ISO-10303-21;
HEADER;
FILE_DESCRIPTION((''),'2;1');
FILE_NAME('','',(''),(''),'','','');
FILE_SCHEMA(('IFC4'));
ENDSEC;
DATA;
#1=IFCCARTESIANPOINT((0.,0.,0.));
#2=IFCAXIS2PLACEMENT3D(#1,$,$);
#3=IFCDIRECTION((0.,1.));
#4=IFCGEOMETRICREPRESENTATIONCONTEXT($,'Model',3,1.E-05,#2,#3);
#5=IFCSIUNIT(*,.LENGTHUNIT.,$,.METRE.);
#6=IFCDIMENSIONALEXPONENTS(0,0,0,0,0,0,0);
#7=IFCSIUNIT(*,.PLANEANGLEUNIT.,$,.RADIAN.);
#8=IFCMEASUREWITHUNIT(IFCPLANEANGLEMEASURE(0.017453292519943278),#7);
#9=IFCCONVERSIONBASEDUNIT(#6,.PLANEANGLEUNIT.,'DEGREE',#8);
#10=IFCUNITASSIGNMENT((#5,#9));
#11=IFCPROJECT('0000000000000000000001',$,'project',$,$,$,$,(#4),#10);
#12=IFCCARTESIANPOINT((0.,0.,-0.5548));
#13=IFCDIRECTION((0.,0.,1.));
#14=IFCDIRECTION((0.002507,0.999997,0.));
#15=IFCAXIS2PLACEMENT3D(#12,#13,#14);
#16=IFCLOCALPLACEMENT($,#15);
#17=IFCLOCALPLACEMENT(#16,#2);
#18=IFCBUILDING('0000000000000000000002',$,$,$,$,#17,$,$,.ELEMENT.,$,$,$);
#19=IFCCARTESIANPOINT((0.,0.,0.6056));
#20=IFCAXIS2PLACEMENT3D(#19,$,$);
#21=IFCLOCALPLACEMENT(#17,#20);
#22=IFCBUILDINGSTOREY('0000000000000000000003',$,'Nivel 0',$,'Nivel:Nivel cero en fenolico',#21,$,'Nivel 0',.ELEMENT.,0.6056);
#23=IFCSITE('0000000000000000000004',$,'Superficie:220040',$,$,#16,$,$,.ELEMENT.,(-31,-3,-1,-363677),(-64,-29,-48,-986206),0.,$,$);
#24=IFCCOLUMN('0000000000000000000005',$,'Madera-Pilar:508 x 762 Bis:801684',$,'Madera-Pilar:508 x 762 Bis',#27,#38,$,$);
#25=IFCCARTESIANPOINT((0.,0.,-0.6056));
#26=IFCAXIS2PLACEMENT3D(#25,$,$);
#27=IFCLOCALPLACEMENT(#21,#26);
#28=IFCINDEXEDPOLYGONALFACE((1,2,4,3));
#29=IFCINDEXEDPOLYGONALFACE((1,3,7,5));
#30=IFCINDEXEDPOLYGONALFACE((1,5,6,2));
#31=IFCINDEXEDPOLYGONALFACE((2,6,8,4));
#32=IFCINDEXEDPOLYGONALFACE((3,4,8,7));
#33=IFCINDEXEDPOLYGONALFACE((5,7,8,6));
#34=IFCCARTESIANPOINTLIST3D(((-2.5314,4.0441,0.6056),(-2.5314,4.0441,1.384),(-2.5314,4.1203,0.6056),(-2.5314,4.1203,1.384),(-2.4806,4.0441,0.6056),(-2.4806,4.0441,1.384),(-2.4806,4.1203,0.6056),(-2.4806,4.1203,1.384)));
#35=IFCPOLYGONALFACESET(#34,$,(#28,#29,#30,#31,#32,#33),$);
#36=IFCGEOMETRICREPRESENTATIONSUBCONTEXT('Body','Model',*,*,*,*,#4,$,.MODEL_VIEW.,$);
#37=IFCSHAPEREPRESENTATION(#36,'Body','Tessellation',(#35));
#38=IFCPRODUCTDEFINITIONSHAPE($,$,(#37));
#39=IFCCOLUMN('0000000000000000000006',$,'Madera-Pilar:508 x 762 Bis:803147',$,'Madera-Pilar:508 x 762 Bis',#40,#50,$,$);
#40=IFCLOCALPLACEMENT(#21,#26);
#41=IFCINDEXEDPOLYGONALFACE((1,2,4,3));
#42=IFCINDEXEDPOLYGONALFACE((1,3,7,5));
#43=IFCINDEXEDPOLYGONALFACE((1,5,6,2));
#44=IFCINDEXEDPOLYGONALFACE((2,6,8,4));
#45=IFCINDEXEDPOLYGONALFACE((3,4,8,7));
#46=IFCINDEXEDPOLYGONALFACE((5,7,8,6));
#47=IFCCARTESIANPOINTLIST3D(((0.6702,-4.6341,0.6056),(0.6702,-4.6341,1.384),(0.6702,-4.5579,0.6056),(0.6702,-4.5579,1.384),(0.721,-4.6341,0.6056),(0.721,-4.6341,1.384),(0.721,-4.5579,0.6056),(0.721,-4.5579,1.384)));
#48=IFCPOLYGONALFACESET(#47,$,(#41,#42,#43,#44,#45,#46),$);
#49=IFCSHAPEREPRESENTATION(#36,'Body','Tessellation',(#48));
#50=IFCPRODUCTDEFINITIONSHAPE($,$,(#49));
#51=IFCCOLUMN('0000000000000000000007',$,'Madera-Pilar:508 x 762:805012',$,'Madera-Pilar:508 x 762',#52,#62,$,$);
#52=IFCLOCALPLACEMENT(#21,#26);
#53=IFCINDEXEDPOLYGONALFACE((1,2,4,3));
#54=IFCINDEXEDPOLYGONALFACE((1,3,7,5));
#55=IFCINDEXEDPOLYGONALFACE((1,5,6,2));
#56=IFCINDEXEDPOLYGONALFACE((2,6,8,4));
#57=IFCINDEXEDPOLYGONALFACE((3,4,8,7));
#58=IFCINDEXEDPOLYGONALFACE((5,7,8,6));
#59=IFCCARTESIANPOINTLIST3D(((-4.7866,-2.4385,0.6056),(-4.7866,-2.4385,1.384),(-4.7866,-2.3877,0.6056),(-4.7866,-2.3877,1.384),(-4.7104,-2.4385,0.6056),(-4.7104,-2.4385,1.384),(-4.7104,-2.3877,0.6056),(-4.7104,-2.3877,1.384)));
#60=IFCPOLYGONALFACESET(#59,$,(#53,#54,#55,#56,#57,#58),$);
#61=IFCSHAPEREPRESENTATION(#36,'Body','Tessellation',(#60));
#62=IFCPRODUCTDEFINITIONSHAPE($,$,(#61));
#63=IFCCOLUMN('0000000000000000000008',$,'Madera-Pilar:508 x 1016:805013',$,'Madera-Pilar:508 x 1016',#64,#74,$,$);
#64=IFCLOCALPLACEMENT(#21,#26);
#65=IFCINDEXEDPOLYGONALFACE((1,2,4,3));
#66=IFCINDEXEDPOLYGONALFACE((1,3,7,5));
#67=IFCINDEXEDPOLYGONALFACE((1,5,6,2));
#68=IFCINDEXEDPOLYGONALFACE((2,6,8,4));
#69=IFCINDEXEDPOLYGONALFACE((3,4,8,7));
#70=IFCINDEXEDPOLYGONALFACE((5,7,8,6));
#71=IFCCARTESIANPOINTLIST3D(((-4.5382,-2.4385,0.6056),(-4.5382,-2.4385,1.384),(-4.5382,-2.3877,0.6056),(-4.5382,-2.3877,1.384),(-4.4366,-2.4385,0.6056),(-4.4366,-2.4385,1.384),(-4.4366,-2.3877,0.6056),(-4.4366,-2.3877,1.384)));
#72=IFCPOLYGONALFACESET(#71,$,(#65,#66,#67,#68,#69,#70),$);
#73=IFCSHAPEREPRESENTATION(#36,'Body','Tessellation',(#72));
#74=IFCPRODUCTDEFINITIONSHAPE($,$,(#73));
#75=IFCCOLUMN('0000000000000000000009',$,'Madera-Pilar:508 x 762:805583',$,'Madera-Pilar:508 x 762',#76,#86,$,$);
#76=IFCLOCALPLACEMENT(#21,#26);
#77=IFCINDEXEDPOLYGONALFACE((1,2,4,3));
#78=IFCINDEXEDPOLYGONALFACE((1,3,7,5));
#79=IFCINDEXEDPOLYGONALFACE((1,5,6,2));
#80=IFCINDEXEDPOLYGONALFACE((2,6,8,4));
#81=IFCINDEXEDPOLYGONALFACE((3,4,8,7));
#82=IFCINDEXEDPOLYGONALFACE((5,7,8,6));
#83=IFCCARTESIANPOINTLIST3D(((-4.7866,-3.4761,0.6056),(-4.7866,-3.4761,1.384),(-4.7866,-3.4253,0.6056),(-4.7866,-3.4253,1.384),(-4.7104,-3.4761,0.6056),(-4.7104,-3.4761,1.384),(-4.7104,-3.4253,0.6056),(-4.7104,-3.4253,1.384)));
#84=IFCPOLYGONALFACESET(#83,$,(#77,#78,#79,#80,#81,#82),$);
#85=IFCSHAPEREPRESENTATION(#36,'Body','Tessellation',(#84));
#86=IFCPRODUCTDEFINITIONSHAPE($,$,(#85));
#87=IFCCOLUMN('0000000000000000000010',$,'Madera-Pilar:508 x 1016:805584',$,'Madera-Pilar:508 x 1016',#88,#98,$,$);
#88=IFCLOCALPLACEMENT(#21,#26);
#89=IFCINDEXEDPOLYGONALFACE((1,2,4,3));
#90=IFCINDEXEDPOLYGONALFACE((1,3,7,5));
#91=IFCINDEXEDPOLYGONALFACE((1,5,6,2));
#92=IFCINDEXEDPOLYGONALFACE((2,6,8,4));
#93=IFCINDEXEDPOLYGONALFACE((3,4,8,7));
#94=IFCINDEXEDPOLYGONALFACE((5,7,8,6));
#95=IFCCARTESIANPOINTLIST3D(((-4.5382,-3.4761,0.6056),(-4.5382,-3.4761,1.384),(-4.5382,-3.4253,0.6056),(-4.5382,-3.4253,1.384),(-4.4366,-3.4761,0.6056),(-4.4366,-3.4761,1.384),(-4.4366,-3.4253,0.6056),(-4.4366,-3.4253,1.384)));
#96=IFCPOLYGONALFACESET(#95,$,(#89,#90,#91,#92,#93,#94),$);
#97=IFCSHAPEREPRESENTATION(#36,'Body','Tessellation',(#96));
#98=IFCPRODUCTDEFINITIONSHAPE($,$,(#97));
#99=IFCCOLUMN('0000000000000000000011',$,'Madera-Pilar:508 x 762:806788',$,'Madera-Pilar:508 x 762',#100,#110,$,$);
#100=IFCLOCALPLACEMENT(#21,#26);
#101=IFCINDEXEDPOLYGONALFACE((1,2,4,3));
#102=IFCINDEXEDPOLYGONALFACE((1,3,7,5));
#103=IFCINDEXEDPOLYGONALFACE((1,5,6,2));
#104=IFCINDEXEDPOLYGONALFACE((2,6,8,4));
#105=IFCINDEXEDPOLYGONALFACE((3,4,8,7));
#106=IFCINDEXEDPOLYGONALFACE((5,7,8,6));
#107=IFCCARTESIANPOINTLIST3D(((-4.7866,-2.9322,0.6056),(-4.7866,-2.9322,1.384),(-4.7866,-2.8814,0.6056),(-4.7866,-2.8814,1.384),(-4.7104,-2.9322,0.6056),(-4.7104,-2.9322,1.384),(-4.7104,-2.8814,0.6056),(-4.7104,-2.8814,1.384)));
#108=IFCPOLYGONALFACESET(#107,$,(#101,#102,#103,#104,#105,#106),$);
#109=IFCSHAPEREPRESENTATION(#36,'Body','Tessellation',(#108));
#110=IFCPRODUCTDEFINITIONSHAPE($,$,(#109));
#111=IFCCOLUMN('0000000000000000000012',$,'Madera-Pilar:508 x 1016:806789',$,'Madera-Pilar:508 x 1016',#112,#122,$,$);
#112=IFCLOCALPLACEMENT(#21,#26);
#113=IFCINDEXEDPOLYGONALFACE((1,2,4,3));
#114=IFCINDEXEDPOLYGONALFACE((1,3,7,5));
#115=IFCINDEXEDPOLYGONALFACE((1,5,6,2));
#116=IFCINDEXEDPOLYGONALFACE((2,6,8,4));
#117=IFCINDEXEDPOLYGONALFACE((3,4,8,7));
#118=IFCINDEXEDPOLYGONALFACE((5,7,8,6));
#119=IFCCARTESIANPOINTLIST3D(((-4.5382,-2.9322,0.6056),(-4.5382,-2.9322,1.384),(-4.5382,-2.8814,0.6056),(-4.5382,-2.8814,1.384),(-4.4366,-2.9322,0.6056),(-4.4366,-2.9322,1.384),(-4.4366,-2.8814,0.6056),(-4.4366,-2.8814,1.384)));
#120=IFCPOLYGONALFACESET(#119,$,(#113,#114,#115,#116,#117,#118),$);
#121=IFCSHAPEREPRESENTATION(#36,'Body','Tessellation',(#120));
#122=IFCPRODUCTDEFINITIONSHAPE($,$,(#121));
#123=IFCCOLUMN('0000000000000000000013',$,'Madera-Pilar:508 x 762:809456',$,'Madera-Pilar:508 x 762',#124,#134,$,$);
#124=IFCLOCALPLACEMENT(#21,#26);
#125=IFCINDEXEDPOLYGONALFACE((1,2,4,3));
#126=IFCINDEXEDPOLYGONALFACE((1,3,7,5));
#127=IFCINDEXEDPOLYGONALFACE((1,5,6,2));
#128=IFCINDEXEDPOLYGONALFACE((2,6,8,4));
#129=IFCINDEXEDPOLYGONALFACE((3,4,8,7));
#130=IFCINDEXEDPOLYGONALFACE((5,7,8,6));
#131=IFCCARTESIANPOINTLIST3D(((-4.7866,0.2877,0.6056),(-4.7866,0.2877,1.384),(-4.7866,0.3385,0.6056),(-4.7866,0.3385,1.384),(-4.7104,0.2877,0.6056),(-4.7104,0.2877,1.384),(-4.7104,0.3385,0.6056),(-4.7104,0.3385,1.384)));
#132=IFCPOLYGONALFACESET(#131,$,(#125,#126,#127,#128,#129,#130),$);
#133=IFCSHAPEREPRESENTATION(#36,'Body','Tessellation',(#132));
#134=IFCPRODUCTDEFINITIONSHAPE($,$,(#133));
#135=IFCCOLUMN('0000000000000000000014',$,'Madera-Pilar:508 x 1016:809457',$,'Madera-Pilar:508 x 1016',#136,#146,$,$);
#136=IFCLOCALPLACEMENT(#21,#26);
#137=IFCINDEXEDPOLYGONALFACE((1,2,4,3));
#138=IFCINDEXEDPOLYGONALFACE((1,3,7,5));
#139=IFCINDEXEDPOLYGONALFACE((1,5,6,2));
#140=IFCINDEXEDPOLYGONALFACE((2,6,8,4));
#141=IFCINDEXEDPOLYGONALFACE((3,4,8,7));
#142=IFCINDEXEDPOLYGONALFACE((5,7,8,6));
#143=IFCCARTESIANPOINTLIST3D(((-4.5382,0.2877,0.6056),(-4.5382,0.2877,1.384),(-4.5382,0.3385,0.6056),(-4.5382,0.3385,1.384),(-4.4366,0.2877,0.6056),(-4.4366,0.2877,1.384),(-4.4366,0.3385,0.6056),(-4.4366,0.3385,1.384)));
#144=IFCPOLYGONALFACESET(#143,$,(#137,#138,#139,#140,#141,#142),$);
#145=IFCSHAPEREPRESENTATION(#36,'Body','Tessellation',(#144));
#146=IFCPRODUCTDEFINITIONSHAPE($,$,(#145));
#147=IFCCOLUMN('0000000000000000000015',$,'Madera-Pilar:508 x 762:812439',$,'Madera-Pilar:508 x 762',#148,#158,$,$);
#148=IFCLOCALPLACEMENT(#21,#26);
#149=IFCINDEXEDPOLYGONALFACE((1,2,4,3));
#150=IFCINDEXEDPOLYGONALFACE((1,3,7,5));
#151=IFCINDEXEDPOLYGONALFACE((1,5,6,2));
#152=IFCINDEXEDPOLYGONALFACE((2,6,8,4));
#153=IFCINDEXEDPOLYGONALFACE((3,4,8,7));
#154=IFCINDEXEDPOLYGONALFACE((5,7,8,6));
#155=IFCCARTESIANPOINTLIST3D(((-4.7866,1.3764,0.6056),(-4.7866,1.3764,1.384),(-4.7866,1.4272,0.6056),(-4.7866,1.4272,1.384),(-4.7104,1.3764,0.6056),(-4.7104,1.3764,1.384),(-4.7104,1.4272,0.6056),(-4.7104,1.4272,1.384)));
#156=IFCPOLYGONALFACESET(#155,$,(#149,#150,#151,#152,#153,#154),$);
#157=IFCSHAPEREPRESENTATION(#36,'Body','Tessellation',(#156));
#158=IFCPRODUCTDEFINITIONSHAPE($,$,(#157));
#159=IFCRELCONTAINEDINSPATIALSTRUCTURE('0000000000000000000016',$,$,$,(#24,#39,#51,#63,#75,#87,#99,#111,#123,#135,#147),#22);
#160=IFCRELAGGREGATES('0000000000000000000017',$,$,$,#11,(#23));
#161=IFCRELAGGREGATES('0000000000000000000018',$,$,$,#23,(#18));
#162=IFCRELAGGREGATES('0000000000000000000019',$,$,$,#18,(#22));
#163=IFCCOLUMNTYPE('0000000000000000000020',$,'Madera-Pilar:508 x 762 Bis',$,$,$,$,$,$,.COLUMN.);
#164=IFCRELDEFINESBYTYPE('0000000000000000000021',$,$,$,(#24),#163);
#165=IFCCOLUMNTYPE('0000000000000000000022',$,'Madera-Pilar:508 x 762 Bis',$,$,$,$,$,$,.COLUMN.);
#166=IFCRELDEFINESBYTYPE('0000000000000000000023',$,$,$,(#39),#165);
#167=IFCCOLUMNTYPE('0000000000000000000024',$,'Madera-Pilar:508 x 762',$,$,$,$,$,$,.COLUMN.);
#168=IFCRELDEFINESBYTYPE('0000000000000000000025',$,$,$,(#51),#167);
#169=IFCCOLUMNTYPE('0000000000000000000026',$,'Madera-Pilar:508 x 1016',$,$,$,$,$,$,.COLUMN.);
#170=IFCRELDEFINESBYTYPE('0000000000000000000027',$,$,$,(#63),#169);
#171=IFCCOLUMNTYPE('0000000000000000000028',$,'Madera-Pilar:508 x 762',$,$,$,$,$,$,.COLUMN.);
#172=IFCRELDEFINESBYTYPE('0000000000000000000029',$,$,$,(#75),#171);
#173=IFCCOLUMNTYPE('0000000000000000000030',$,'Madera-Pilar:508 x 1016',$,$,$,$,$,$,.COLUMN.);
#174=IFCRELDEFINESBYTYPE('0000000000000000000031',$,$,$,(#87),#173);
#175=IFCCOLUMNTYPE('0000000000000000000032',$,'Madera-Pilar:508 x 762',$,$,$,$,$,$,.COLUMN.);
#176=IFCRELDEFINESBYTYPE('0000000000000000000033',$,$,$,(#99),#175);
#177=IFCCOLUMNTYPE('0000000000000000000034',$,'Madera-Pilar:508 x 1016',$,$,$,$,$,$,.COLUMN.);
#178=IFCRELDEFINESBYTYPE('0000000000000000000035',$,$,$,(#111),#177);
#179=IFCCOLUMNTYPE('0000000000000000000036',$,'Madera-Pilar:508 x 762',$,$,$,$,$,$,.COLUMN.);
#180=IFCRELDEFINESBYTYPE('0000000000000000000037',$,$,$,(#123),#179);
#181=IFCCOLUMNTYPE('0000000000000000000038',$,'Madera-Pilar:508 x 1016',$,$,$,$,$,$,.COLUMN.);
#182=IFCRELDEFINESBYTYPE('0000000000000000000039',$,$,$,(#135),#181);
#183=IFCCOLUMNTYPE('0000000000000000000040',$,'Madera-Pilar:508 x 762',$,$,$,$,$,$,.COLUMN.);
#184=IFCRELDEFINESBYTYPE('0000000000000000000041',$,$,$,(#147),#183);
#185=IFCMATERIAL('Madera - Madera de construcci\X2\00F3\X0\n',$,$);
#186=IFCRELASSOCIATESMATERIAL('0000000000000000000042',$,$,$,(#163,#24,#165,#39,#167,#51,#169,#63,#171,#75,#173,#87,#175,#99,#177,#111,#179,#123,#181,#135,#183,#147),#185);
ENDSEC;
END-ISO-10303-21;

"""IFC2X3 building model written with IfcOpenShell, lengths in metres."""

from ifc_helpers import new_model, entity, si_unit, converted_unit, direction, frame, frame_2d, origin, origin_2d_with_axis, place, context, subcontext, project, spatial, rectangle, extrude, source, transform, mapped, material, type_object, type_shapes, element, save


model = new_model("IFC2X3")

# Units and contexts
model_context = context("Model", 3, precision=1e-05, world=origin(), true_north=direction((0.0, 1.0)))
body_context = subcontext(model_context, "Body", "Model", "MODEL_VIEW")
ifc_project = project(units=[si_unit("LENGTHUNIT", "METRE"), converted_unit("PLANEANGLEUNIT", "DEGREE", entity("IfcPlaneAngleMeasure", 0.017453292519943278), si_unit("PLANEANGLEUNIT", "RADIAN"), dimensions=[0, 0, 0, 0, 0, 0, 0])], contexts=[model_context])

# Site, building, storey
site_placement = place(None, frame((0.0, 0.0, -0.5548), z_axis=(0.0, 0.0, 1.0), x_axis=(0.002507, 0.999997, 0.0)))
site = spatial("IfcSite", under=ifc_project, at=site_placement, Name="Superficie:220040", CompositionType="ELEMENT", RefLatitude=(-31, -3, -1, -363677), RefLongitude=(-64, -29, -48, -986206), RefElevation=0.0)
building_placement = place(site_placement, origin())
building = spatial("IfcBuilding", under=site, at=building_placement, CompositionType="ELEMENT")
storey_placement = place(building_placement, frame((0.0, 0.0, 0.6056)))
storey = spatial("IfcBuildingStorey", under=building, at=storey_placement, Name="Nivel 0", ObjectType="Nivel:Nivel cero en fenolico", LongName="Nivel 0", CompositionType="ELEMENT", Elevation=0.6056)

# Columns
ifc_material = material(Name="Madera - Madera de construcción")
column_type_1 = type_object("IfcColumnType", Name="Madera-Pilar:508 x 762 Bis", PredefinedType="COLUMN", material=ifc_material)
shared_shape_1 = source(origin(), body_context, "Body", "SweptSolid", [
    extrude(rectangle(XDim=0.0508, YDim=0.0762, at=frame_2d((0.0, 0.0), x_axis=(1.0, 0.0))), frame((-2.506, 4.0822, 0.6056), z_axis=(0.0, 0.0, 1.0), x_axis=(-1.0, 0.0, 0.0)), (0.0, 0.0, 1.0), 0.7784),
])
type_shapes(column_type_1, [shared_shape_1])
column_1_placement = place(storey_placement, frame((0.0, 0.0, -0.6056)))
element("IfcColumn", 1, at=column_1_placement, inside=storey, type_object=column_type_1, material=ifc_material, Name="Madera-Pilar:508 x 762 Bis:801684", ObjectType="Madera-Pilar:508 x 762 Bis", context=body_context, shape_type="MappedRepresentation", body=[
    mapped(shared_shape_1, transform((0.0, 0.0, 0.0), scale=1.0)),
])
column_type_2 = type_object("IfcColumnType", Name="Madera-Pilar:508 x 762 Bis", PredefinedType="COLUMN", material=ifc_material)
shared_shape_2 = source(origin(), body_context, "Body", "SweptSolid", [
    extrude(rectangle(XDim=0.0508, YDim=0.0762, at=frame_2d((0.0, 0.0), x_axis=(1.0, 0.0))), frame((0.6956, -4.596, 0.6056)), (0.0, 0.0, 1.0), 0.7784),
])
type_shapes(column_type_2, [shared_shape_2])
column_2_placement = place(storey_placement, frame((0.0, 0.0, -0.6056)))
element("IfcColumn", 2, at=column_2_placement, inside=storey, type_object=column_type_2, material=ifc_material, Name="Madera-Pilar:508 x 762 Bis:803147", ObjectType="Madera-Pilar:508 x 762 Bis", context=body_context, shape_type="MappedRepresentation", body=[
    mapped(shared_shape_2, transform((0.0, 0.0, 0.0), scale=1.0)),
])
column_type_3 = type_object("IfcColumnType", Name="Madera-Pilar:508 x 762", PredefinedType="COLUMN", material=ifc_material)
shared_shape_3 = source(origin(), body_context, "Body", "SweptSolid", [
    extrude(rectangle(XDim=0.0762, YDim=0.0508, at=origin_2d_with_axis()), frame((-4.7485, -2.4131, 0.6056), z_axis=(0.0, 0.0, 1.0), x_axis=(-1.0, 0.0, 0.0)), (0.0, 0.0, 1.0), 0.7784),
])
type_shapes(column_type_3, [shared_shape_3])
column_3_placement = place(storey_placement, frame((0.0, 0.0, -0.6056)))
element("IfcColumn", 3, at=column_3_placement, inside=storey, type_object=column_type_3, material=ifc_material, Name="Madera-Pilar:508 x 762:805012", ObjectType="Madera-Pilar:508 x 762", context=body_context, shape_type="MappedRepresentation", body=[
    mapped(shared_shape_3, transform((0.0, 0.0, 0.0), scale=1.0)),
])
column_type_4 = type_object("IfcColumnType", Name="Madera-Pilar:508 x 1016", PredefinedType="COLUMN", material=ifc_material)
shared_shape_4 = source(origin(), body_context, "Body", "SweptSolid", [
    extrude(rectangle(XDim=0.1016, YDim=0.0508, at=frame_2d((0.0, 0.0), x_axis=(1.0, 0.0))), frame((-4.4874, -2.4131, 0.6056), z_axis=(0.0, 0.0, 1.0), x_axis=(-1.0, 0.0, 0.0)), (0.0, 0.0, 1.0), 0.7784),
])
type_shapes(column_type_4, [shared_shape_4])
column_4_placement = place(storey_placement, frame((0.0, 0.0, -0.6056)))
element("IfcColumn", 4, at=column_4_placement, inside=storey, type_object=column_type_4, material=ifc_material, Name="Madera-Pilar:508 x 1016:805013", ObjectType="Madera-Pilar:508 x 1016", context=body_context, shape_type="MappedRepresentation", body=[
    mapped(shared_shape_4, transform((0.0, 0.0, 0.0), scale=1.0)),
])
column_type_5 = type_object("IfcColumnType", Name="Madera-Pilar:508 x 762", PredefinedType="COLUMN", material=ifc_material)
shared_shape_5 = source(origin(), body_context, "Body", "SweptSolid", [
    extrude(rectangle(XDim=0.0762, YDim=0.0508, at=frame_2d((0.0, 0.0), x_axis=(1.0, 0.0))), frame((-4.7485, -3.4507, 0.6056), z_axis=(0.0, 0.0, 1.0), x_axis=(-1.0, 0.0, 0.0)), (0.0, 0.0, 1.0), 0.7784),
])
type_shapes(column_type_5, [shared_shape_5])
column_5_placement = place(storey_placement, frame((0.0, 0.0, -0.6056)))
element("IfcColumn", 5, at=column_5_placement, inside=storey, type_object=column_type_5, material=ifc_material, Name="Madera-Pilar:508 x 762:805583", ObjectType="Madera-Pilar:508 x 762", context=body_context, shape_type="MappedRepresentation", body=[
    mapped(shared_shape_5, transform((0.0, 0.0, 0.0), scale=1.0)),
])
column_type_6 = type_object("IfcColumnType", Name="Madera-Pilar:508 x 1016", PredefinedType="COLUMN", material=ifc_material)
shared_shape_6 = source(origin(), body_context, "Body", "SweptSolid", [
    extrude(rectangle(XDim=0.1016, YDim=0.0508, at=frame_2d((0.0, 0.0), x_axis=(1.0, 0.0))), frame((-4.4874, -3.4507, 0.6056), z_axis=(0.0, 0.0, 1.0), x_axis=(-1.0, 0.0, 0.0)), (0.0, 0.0, 1.0), 0.7784),
])
type_shapes(column_type_6, [shared_shape_6])
column_6_placement = place(storey_placement, frame((0.0, 0.0, -0.6056)))
element("IfcColumn", 6, at=column_6_placement, inside=storey, type_object=column_type_6, material=ifc_material, Name="Madera-Pilar:508 x 1016:805584", ObjectType="Madera-Pilar:508 x 1016", context=body_context, shape_type="MappedRepresentation", body=[
    mapped(shared_shape_6, transform((0.0, 0.0, 0.0), scale=1.0)),
])
column_type_7 = type_object("IfcColumnType", Name="Madera-Pilar:508 x 762", PredefinedType="COLUMN", material=ifc_material)
shared_shape_7 = source(origin(), body_context, "Body", "SweptSolid", [
    extrude(rectangle(XDim=0.0762, YDim=0.0508, at=frame_2d((0.0, 0.0), x_axis=(1.0, 0.0))), frame((-4.7485, -2.9068, 0.6056), z_axis=(0.0, 0.0, 1.0), x_axis=(-1.0, 0.0, 0.0)), (0.0, 0.0, 1.0), 0.7784),
])
type_shapes(column_type_7, [shared_shape_7])
column_7_placement = place(storey_placement, frame((0.0, 0.0, -0.6056)))
element("IfcColumn", 7, at=column_7_placement, inside=storey, type_object=column_type_7, material=ifc_material, Name="Madera-Pilar:508 x 762:806788", ObjectType="Madera-Pilar:508 x 762", context=body_context, shape_type="MappedRepresentation", body=[
    mapped(shared_shape_7, transform((0.0, 0.0, 0.0), scale=1.0)),
])
column_type_8 = type_object("IfcColumnType", Name="Madera-Pilar:508 x 1016", PredefinedType="COLUMN", material=ifc_material)
shared_shape_8 = source(origin(), body_context, "Body", "SweptSolid", [
    extrude(rectangle(XDim=0.1016, YDim=0.0508, at=frame_2d((0.0, 0.0), x_axis=(1.0, 0.0))), frame((-4.4874, -2.9068, 0.6056), z_axis=(0.0, 0.0, 1.0), x_axis=(-1.0, 0.0, 0.0)), (0.0, 0.0, 1.0), 0.7784),
])
type_shapes(column_type_8, [shared_shape_8])
column_8_placement = place(storey_placement, frame((0.0, 0.0, -0.6056)))
element("IfcColumn", 8, at=column_8_placement, inside=storey, type_object=column_type_8, material=ifc_material, Name="Madera-Pilar:508 x 1016:806789", ObjectType="Madera-Pilar:508 x 1016", context=body_context, shape_type="MappedRepresentation", body=[
    mapped(shared_shape_8, transform((0.0, 0.0, 0.0), scale=1.0)),
])
column_type_9 = type_object("IfcColumnType", Name="Madera-Pilar:508 x 762", PredefinedType="COLUMN", material=ifc_material)
shared_shape_9 = source(origin(), body_context, "Body", "SweptSolid", [
    extrude(rectangle(XDim=0.0762, YDim=0.0508, at=frame_2d((0.0, 0.0), x_axis=(1.0, 0.0))), frame((-4.7485, 0.3131, 0.6056), z_axis=(0.0, 0.0, 1.0), x_axis=(-1.0, 0.0, 0.0)), (0.0, 0.0, 1.0), 0.7784),
])
type_shapes(column_type_9, [shared_shape_9])
column_9_placement = place(storey_placement, frame((0.0, 0.0, -0.6056)))
element("IfcColumn", 9, at=column_9_placement, inside=storey, type_object=column_type_9, material=ifc_material, Name="Madera-Pilar:508 x 762:809456", ObjectType="Madera-Pilar:508 x 762", context=body_context, shape_type="MappedRepresentation", body=[
    mapped(shared_shape_9, transform((0.0, 0.0, 0.0), scale=1.0)),
])
column_type_10 = type_object("IfcColumnType", Name="Madera-Pilar:508 x 1016", PredefinedType="COLUMN", material=ifc_material)
shared_shape_10 = source(origin(), body_context, "Body", "SweptSolid", [
    extrude(rectangle(XDim=0.1016, YDim=0.0508, at=frame_2d((0.0, 0.0), x_axis=(1.0, 0.0))), frame((-4.4874, 0.3131, 0.6056), z_axis=(0.0, 0.0, 1.0), x_axis=(-1.0, 0.0, 0.0)), (0.0, 0.0, 1.0), 0.7784),
])
type_shapes(column_type_10, [shared_shape_10])
column_10_placement = place(storey_placement, frame((0.0, 0.0, -0.6056)))
element("IfcColumn", 10, at=column_10_placement, inside=storey, type_object=column_type_10, material=ifc_material, Name="Madera-Pilar:508 x 1016:809457", ObjectType="Madera-Pilar:508 x 1016", context=body_context, shape_type="MappedRepresentation", body=[
    mapped(shared_shape_10, transform((0.0, 0.0, 0.0), scale=1.0)),
])
column_type_11 = type_object("IfcColumnType", Name="Madera-Pilar:508 x 762", PredefinedType="COLUMN", material=ifc_material)
shared_shape_11 = source(origin(), body_context, "Body", "SweptSolid", [
    extrude(rectangle(XDim=0.0762, YDim=0.0508, at=frame_2d((0.0, 0.0), x_axis=(1.0, 0.0))), frame((-4.7485, 1.4018, 0.6056), z_axis=(0.0, 0.0, 1.0), x_axis=(-1.0, 0.0, 0.0)), (0.0, 0.0, 1.0), 0.7784),
])
type_shapes(column_type_11, [shared_shape_11])
column_11_placement = place(storey_placement, frame((0.0, 0.0, -0.6056)))
element("IfcColumn", 11, at=column_11_placement, inside=storey, type_object=column_type_11, material=ifc_material, Name="Madera-Pilar:508 x 762:812439", ObjectType="Madera-Pilar:508 x 762", context=body_context, shape_type="MappedRepresentation", body=[
    mapped(shared_shape_11, transform((0.0, 0.0, 0.0), scale=1.0)),
])

save(model, "model.ifc")
